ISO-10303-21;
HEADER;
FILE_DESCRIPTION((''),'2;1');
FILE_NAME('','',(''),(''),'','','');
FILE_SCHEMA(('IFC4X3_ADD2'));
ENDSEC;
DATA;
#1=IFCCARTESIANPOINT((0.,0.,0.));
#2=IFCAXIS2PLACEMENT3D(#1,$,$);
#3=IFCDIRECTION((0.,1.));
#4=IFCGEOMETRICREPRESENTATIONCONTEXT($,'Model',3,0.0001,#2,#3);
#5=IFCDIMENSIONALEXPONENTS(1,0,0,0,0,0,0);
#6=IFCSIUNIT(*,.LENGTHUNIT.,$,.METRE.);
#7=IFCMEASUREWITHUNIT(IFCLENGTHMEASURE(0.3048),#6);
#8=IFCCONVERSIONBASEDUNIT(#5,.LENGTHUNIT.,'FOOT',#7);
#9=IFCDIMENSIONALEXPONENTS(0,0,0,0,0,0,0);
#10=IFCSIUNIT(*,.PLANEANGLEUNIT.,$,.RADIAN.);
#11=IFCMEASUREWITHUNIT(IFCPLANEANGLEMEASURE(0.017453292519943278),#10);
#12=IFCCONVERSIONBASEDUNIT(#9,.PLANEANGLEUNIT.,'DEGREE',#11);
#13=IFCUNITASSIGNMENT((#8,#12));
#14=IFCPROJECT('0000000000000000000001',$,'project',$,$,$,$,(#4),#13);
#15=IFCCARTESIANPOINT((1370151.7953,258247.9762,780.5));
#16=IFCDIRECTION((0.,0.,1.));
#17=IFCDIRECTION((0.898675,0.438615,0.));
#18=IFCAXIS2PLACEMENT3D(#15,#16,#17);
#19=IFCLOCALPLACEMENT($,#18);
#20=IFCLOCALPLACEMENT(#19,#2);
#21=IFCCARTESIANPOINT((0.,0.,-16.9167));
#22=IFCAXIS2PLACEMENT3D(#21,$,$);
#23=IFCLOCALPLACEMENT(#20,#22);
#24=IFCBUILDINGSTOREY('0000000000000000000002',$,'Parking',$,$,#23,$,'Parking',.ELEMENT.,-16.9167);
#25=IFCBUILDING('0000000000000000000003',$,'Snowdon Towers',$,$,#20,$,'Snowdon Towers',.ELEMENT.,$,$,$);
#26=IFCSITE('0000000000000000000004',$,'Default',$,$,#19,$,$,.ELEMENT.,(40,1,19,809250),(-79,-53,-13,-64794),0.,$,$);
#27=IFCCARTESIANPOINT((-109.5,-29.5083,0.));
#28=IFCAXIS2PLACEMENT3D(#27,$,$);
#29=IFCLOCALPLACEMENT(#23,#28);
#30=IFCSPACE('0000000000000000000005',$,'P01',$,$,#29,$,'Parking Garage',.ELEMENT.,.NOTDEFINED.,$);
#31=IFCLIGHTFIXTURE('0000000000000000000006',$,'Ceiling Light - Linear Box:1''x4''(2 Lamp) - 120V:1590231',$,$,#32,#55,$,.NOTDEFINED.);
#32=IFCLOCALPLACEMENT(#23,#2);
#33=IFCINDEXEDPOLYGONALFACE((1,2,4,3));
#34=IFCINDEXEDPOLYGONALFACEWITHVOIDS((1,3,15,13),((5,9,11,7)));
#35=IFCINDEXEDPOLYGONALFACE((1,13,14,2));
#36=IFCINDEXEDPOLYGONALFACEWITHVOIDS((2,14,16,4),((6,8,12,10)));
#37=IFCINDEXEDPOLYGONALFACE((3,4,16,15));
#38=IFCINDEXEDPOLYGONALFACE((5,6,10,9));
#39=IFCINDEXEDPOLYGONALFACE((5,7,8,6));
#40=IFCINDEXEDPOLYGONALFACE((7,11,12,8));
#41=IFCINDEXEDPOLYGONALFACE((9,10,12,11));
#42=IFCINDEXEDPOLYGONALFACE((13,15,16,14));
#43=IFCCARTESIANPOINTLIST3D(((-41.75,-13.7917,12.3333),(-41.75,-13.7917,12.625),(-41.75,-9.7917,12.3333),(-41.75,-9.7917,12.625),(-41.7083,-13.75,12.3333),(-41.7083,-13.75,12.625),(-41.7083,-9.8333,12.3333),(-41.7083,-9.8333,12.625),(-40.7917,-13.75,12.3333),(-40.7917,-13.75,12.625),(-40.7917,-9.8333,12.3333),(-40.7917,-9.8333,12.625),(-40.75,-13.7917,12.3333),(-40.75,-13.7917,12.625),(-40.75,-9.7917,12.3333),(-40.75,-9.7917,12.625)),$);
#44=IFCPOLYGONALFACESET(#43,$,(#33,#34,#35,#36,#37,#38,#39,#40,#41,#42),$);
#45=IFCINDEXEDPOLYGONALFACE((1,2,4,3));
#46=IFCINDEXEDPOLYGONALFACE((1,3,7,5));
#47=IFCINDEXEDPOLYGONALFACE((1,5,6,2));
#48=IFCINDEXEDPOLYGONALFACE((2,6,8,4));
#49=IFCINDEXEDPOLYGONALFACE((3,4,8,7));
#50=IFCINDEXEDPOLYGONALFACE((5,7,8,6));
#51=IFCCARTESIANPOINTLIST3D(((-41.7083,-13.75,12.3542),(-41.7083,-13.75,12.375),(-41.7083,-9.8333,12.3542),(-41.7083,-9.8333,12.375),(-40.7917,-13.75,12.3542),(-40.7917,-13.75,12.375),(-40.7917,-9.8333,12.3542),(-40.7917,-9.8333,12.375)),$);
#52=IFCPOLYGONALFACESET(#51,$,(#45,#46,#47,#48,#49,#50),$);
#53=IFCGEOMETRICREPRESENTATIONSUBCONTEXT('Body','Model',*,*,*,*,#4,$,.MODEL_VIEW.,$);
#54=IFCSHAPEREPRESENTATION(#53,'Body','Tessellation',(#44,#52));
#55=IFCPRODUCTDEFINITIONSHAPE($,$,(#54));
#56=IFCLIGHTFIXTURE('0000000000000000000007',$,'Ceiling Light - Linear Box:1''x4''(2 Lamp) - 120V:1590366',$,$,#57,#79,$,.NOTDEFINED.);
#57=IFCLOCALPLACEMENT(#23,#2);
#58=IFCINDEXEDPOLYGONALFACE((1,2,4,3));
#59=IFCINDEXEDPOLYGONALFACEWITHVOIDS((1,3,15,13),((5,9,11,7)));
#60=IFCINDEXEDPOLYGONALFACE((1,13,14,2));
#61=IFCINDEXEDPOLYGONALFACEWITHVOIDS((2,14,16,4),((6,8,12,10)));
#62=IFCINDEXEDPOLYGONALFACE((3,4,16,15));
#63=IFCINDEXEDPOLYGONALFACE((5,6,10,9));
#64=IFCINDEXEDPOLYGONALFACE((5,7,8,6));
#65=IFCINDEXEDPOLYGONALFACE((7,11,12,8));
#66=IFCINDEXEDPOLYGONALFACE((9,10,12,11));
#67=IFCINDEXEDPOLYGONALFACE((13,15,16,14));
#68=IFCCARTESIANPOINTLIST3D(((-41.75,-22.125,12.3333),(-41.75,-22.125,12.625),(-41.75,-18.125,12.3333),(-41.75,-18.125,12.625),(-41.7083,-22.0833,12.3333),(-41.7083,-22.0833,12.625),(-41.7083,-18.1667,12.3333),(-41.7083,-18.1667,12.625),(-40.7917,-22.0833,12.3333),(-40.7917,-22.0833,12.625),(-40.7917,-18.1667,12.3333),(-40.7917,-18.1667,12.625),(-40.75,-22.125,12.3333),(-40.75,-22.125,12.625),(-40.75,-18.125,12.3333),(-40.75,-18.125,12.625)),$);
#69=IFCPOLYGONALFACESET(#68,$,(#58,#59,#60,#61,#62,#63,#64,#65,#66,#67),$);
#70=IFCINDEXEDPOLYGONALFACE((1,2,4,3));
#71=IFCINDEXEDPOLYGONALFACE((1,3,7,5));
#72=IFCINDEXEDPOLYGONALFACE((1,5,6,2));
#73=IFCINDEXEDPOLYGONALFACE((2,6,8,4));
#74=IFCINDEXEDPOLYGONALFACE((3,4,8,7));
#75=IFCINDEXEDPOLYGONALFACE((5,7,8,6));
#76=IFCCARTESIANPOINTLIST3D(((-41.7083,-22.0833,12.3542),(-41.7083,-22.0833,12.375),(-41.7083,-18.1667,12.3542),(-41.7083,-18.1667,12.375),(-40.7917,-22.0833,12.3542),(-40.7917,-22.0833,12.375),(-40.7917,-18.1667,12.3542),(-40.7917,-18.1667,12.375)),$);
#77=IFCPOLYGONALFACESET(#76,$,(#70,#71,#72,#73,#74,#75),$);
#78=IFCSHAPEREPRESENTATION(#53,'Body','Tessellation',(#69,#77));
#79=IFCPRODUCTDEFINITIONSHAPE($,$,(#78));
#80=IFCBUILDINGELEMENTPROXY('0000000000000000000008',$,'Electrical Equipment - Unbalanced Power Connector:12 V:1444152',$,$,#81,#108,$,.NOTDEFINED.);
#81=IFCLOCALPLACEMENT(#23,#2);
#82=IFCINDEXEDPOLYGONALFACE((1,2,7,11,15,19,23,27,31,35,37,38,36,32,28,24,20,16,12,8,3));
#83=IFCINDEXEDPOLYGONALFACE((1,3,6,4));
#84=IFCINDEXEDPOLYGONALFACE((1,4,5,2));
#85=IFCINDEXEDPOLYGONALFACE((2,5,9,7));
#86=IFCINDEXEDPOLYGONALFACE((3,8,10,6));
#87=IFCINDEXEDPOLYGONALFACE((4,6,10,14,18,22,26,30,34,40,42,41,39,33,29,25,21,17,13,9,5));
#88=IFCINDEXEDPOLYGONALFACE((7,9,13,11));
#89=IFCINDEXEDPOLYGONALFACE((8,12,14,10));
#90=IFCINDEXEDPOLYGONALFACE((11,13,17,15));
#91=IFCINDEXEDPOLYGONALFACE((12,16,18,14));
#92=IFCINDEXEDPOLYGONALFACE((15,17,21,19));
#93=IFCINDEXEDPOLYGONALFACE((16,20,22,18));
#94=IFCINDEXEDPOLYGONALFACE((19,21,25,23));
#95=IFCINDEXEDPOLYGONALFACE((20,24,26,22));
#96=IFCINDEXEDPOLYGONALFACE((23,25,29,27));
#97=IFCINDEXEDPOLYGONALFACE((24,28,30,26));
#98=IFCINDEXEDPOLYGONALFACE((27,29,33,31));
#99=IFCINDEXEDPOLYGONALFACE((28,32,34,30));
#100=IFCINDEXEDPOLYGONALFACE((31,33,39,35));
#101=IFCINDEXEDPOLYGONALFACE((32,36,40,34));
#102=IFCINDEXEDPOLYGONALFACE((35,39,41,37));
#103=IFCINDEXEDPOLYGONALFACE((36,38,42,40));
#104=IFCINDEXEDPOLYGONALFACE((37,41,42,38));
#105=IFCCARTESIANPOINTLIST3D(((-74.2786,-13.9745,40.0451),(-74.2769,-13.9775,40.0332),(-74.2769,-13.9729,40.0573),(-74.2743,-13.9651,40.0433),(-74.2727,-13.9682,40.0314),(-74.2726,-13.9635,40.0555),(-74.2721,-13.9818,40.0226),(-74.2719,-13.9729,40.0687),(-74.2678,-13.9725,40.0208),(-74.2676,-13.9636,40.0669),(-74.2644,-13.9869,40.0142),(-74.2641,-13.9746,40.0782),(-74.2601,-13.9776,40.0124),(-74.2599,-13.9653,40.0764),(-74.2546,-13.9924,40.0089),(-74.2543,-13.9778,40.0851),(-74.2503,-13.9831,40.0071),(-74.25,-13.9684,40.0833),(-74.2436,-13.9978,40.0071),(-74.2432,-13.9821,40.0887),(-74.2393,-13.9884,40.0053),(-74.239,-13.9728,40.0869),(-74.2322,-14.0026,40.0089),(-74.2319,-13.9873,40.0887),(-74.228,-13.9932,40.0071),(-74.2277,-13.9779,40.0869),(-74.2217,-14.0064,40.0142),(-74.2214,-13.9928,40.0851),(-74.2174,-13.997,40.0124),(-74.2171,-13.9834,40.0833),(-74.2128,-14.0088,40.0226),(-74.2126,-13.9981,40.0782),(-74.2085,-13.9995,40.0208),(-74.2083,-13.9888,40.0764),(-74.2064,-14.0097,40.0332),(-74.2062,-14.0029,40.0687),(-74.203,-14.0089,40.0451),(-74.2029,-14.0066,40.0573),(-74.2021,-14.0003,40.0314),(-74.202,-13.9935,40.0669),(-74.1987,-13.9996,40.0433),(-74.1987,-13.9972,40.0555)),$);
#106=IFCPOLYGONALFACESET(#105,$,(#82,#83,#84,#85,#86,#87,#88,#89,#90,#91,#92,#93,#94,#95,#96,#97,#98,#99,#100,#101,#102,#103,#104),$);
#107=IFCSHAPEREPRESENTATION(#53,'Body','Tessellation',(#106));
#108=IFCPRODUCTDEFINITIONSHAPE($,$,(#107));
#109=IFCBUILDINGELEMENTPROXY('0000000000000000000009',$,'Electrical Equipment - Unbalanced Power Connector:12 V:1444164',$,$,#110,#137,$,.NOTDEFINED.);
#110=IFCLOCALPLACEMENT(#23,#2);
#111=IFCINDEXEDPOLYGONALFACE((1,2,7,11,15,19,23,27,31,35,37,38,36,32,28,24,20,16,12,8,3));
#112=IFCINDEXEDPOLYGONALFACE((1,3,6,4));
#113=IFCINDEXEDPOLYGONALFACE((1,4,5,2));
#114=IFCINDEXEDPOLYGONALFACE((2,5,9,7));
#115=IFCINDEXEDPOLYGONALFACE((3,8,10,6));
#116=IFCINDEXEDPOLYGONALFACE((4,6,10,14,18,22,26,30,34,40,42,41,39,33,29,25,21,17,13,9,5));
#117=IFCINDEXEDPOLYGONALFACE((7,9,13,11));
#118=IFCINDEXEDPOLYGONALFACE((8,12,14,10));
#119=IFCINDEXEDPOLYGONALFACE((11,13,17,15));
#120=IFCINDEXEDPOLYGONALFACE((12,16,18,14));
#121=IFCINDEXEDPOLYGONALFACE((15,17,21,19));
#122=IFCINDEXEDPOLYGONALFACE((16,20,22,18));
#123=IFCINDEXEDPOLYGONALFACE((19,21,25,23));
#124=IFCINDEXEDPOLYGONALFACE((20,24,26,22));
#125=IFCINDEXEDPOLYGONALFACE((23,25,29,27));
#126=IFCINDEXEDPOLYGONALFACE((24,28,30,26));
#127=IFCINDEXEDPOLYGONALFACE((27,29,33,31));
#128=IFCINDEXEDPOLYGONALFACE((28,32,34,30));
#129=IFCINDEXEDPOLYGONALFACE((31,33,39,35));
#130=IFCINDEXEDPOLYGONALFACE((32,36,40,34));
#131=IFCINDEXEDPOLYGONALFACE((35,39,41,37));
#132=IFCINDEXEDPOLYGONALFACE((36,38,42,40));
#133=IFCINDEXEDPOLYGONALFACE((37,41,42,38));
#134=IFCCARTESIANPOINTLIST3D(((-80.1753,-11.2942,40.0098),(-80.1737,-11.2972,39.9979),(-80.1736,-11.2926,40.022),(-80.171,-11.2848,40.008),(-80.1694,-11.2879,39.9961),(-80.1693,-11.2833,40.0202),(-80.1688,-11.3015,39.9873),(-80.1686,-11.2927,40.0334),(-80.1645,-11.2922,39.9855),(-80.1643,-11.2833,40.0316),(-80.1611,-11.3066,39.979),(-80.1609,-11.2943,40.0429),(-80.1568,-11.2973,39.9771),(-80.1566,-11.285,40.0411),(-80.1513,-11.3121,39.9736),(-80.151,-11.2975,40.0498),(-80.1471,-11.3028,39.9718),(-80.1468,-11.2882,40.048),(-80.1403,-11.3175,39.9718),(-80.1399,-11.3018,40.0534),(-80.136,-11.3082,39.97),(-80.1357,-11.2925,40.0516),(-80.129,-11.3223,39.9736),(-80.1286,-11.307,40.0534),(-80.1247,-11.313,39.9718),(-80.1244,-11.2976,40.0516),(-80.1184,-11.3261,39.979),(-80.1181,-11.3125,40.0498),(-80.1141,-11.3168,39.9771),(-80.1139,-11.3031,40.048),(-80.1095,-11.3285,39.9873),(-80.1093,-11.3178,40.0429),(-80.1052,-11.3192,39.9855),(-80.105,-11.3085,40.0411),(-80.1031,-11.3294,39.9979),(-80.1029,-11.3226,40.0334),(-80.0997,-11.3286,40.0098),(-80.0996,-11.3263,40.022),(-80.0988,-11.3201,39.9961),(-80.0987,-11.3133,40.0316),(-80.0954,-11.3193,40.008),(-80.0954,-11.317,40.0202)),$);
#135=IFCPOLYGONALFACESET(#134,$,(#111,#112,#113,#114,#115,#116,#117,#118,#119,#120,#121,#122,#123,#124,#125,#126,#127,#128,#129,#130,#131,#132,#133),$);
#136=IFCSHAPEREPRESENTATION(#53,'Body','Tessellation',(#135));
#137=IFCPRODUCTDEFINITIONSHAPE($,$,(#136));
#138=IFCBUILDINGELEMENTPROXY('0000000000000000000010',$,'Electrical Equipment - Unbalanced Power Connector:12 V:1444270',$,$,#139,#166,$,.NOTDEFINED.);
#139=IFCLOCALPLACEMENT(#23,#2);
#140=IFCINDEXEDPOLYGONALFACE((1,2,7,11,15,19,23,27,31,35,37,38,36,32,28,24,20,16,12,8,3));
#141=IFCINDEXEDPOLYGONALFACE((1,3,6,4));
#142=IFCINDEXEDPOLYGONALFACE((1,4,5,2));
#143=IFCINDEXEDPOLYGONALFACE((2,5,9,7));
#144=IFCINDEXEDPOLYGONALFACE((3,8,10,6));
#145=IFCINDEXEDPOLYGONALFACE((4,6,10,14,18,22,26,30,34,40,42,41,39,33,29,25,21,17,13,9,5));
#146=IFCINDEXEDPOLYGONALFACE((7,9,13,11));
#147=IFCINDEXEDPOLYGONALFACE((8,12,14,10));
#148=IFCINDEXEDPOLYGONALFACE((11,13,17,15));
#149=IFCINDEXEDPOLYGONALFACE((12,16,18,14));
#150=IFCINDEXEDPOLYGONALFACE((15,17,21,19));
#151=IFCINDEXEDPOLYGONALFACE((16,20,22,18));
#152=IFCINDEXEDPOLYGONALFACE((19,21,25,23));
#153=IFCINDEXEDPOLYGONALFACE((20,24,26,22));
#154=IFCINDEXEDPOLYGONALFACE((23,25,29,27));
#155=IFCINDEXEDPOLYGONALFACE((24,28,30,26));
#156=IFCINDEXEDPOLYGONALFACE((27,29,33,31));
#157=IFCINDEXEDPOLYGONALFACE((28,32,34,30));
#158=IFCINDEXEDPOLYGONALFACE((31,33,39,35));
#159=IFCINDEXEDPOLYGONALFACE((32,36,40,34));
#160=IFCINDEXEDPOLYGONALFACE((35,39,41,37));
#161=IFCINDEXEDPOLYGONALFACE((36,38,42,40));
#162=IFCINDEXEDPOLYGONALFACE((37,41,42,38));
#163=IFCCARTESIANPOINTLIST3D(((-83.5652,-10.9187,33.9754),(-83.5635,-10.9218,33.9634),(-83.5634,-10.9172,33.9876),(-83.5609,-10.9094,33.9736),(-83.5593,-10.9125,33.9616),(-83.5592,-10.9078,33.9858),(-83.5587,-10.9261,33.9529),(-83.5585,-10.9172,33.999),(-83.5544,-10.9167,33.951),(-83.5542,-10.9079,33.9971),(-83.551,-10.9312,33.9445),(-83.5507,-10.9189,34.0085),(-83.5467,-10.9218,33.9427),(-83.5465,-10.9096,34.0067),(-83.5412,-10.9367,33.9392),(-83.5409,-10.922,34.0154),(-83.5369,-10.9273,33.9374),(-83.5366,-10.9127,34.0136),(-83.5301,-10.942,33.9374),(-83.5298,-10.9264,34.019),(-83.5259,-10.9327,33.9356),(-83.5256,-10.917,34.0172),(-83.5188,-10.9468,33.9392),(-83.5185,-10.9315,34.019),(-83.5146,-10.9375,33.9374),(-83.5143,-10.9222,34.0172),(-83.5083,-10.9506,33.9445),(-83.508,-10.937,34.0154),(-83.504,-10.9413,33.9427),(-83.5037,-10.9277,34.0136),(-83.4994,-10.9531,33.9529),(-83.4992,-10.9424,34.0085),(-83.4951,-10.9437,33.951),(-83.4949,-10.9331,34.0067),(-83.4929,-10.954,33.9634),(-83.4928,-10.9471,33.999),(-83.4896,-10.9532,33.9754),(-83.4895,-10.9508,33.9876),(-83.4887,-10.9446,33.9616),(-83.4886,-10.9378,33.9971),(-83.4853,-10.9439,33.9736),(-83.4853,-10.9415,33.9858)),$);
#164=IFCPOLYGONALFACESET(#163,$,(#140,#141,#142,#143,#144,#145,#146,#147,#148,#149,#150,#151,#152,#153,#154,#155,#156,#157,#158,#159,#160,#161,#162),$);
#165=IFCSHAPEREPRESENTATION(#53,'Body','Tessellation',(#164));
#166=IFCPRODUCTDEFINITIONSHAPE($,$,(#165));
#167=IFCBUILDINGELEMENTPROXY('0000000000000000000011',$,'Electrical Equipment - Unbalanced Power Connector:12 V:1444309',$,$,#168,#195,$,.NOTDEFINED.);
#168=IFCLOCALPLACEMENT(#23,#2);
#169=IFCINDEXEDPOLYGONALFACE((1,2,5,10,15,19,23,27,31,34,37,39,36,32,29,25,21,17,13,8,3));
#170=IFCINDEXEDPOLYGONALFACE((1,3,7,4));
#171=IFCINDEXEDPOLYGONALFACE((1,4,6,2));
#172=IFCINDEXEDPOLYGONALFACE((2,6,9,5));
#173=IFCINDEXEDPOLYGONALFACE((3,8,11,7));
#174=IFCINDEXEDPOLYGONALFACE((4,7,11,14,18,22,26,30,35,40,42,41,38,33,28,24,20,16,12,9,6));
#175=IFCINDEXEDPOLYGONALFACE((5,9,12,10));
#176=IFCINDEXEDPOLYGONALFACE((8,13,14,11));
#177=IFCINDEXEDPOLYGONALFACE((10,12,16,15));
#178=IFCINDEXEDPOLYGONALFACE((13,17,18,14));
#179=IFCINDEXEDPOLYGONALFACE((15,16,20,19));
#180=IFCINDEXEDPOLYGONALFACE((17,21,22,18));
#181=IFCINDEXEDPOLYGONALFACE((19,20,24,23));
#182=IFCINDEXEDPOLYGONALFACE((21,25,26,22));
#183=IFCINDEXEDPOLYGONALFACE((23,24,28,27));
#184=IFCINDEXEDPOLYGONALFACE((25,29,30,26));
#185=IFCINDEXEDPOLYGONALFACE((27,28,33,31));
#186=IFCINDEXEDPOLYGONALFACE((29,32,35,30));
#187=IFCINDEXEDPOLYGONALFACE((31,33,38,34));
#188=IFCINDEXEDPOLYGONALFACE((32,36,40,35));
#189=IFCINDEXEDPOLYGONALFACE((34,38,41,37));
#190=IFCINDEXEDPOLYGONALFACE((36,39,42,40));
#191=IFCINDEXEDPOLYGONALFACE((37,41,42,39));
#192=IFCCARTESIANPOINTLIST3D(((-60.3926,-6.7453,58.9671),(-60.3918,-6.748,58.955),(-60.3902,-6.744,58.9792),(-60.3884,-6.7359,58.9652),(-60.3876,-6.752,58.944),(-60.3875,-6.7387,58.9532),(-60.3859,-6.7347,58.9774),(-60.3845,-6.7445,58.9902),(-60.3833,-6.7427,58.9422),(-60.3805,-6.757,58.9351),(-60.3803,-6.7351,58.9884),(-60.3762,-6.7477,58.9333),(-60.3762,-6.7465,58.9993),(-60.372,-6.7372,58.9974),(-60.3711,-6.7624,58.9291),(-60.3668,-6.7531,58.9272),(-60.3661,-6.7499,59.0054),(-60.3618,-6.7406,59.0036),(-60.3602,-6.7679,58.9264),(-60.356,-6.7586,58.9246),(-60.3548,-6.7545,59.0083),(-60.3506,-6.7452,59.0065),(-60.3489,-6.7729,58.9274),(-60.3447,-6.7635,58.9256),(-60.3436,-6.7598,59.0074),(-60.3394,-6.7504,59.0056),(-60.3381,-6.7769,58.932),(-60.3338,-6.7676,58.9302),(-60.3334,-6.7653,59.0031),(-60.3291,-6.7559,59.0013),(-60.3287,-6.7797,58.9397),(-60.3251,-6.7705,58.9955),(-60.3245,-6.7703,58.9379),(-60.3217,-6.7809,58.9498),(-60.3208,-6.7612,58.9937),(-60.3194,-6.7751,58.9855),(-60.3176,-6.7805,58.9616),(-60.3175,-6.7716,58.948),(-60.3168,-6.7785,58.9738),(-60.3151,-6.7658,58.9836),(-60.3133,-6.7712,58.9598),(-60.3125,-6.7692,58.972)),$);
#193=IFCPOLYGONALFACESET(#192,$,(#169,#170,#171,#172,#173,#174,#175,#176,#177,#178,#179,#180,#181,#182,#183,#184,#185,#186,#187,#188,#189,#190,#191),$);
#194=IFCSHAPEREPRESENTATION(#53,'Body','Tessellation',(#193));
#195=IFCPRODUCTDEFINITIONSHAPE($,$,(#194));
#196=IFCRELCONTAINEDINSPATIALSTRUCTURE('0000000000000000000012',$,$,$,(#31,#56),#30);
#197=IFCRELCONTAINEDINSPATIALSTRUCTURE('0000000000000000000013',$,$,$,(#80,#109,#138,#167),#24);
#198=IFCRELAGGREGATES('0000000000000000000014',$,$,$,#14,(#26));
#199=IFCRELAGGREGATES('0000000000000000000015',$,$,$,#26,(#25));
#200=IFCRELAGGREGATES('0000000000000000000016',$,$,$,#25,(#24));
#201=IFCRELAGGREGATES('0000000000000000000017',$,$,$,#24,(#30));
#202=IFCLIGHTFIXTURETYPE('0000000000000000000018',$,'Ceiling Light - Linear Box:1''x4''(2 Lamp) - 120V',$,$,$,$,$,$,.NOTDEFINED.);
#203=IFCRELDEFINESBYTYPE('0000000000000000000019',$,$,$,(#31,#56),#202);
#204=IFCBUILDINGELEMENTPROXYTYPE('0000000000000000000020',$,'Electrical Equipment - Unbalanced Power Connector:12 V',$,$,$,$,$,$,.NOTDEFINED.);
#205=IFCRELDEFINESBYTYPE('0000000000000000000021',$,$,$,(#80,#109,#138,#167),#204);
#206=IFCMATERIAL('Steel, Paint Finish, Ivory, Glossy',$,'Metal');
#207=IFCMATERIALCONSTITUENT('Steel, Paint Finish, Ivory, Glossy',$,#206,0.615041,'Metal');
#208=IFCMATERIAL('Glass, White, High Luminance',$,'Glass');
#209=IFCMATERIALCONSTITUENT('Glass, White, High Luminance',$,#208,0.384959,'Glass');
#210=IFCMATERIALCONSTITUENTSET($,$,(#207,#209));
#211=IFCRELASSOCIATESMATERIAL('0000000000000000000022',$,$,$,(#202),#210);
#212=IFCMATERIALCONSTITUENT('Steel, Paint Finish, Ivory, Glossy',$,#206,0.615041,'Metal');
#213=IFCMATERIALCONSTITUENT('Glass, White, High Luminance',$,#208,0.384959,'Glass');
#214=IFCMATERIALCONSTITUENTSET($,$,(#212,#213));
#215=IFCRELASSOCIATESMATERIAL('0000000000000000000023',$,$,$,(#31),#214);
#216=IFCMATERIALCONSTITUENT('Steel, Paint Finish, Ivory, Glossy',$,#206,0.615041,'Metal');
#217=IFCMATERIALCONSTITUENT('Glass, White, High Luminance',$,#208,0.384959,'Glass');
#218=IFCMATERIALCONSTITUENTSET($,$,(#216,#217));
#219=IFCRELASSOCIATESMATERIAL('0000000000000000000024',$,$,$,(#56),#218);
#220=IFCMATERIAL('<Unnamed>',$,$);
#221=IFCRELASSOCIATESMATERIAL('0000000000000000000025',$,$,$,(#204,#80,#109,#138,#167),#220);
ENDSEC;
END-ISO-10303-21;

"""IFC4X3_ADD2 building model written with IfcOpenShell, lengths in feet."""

from ifc_helpers import new_model, entity, si_unit, converted_unit, direction, frame, frame_2d, origin, origin_2d_with_axis, place, context, subcontext, project, spatial, polyline, rectangle, circle, outline, extrude, source, transform, mapped, material, constituent, constituent_set, type_object, type_shapes, element, save


model = new_model("IFC4X3_ADD2")

# Units and contexts
model_context = context("Model", 3, precision=0.0001, world=origin(), true_north=direction((0.0, 1.0)))
body_context = subcontext(model_context, "Body", "Model", "MODEL_VIEW")
ifc_project = project(units=[converted_unit("LENGTHUNIT", "FOOT", entity("IfcLengthMeasure", 0.3048), si_unit("LENGTHUNIT", "METRE"), dimensions=[1, 0, 0, 0, 0, 0, 0]), converted_unit("PLANEANGLEUNIT", "DEGREE", entity("IfcPlaneAngleMeasure", 0.017453292519943278), si_unit("PLANEANGLEUNIT", "RADIAN"), dimensions=[0, 0, 0, 0, 0, 0, 0])], contexts=[model_context])

# Site, building, storey
site_placement = place(None, frame((1370151.7953, 258247.9762, 780.5), z_axis=(0.0, 0.0, 1.0), x_axis=(0.898675, 0.438615, 0.0)))
site = spatial("IfcSite", under=ifc_project, at=site_placement, Name="Default", CompositionType="ELEMENT", RefLatitude=(40, 1, 19, 809250), RefLongitude=(-79, -53, -13, -64794), RefElevation=0.0)
building_placement = place(site_placement, origin())
building = spatial("IfcBuilding", under=site, at=building_placement, Name="Snowdon Towers", LongName="Snowdon Towers", CompositionType="ELEMENT")
storey_placement = place(building_placement, frame((0.0, 0.0, -16.9167)))
storey = spatial("IfcBuildingStorey", under=building, at=storey_placement, Name="Parking", LongName="Parking", CompositionType="ELEMENT", Elevation=-16.9167)

# Shared definitions
space_placement = place(storey_placement, frame((-109.5, -29.5083, 0.0)))
space = spatial("IfcSpace", under=storey, at=space_placement, Name="P01", LongName="Parking Garage", CompositionType="ELEMENT", PredefinedType="NOTDEFINED")

# Light fixtures
ifc_material_1 = material(Name="Steel, Paint Finish, Ivory, Glossy", Category="Metal")
ifc_constituent_1 = constituent(ifc_material_1, Name="Steel, Paint Finish, Ivory, Glossy", Category="Metal", fraction=0.615041)
ifc_material_2 = material(Name="Glass, White, High Luminance", Category="Glass")
ifc_constituent_2 = constituent(ifc_material_2, Name="Glass, White, High Luminance", Category="Glass", fraction=0.384959)
ifc_constituent_set_1 = constituent_set(constituents=[ifc_constituent_1, ifc_constituent_2])
ifc_constituent_3 = constituent(ifc_material_1, Name="Steel, Paint Finish, Ivory, Glossy", Category="Metal", fraction=0.615041)
ifc_constituent_4 = constituent(ifc_material_2, Name="Glass, White, High Luminance", Category="Glass", fraction=0.384959)
ifc_constituent_set_2 = constituent_set(constituents=[ifc_constituent_3, ifc_constituent_4])
light_fixture_type = type_object("IfcLightFixtureType", Name="Ceiling Light - Linear Box:1'x4'(2 Lamp) - 120V", PredefinedType="NOTDEFINED", material=ifc_constituent_set_2)
shared_shape_1 = source(origin(), body_context, "Body", "SweptSolid", [
    extrude(outline(polyline([(-2.0, -0.5), (2.0, -0.5), (2.0, 0.5), (-2.0, 0.5), (-2.0, -0.5)]), holes=[polyline([(-1.9583, -0.4583), (-1.9583, 0.4583), (1.9583, 0.4583), (1.9583, -0.4583), (-1.9583, -0.4583)])]), frame((0.0, -0.5, 0.0), z_axis=(0.0, 0.0, 1.0), x_axis=(-1.0, 0.0, 0.0)), (0.0, 0.0, 1.0), 0.2917),
    extrude(rectangle(XDim=3.9167, YDim=0.9167, at=origin_2d_with_axis()), frame((0.0, -0.5, 0.25), z_axis=(0.0, 0.0, 1.0), x_axis=(-1.0, 0.0, 0.0)), (0.0, 0.0, 1.0), 0.0208),
])
type_shapes(light_fixture_type, [shared_shape_1])
light_fixture_1_placement = place(space_placement, frame((67.75, 17.7166, 12.625), z_axis=(0.0, 0.0, -1.0), x_axis=(0.0, -1.0, 0.0)))
element("IfcLightFixture", 1, at=light_fixture_1_placement, inside=space, type_object=light_fixture_type, material=ifc_constituent_set_1, Name="Ceiling Light - Linear Box:1'x4'(2 Lamp) - 120V:1590231", PredefinedType="NOTDEFINED", context=body_context, shape_type="MappedRepresentation", body=[
    mapped(shared_shape_1, transform((0.0, 0.0, 0.0), scale=1.0)),
])
ifc_constituent_5 = constituent(ifc_material_1, Name="Steel, Paint Finish, Ivory, Glossy", Category="Metal", fraction=0.615041)
ifc_constituent_6 = constituent(ifc_material_2, Name="Glass, White, High Luminance", Category="Glass", fraction=0.384959)
ifc_constituent_set_3 = constituent_set(constituents=[ifc_constituent_5, ifc_constituent_6])
light_fixture_2_placement = place(space_placement, frame((67.75, 9.3833, 12.625), z_axis=(0.0, 0.0, -1.0), x_axis=(0.0, -1.0, 0.0)))
element("IfcLightFixture", 2, at=light_fixture_2_placement, inside=space, type_object=light_fixture_type, material=ifc_constituent_set_3, Name="Ceiling Light - Linear Box:1'x4'(2 Lamp) - 120V:1590366", PredefinedType="NOTDEFINED", context=body_context, shape_type="MappedRepresentation", body=[
    mapped(shared_shape_1, transform((0.0, 0.0, 0.0), scale=1.0)),
])

# Building element proxies
ifc_material_3 = material(Name="<Unnamed>")
building_element_proxy_type = type_object("IfcBuildingElementProxyType", Name="Electrical Equipment - Unbalanced Power Connector:12 V", PredefinedType="NOTDEFINED", material=ifc_material_3)
shared_shape_2 = source(origin(), body_context, "Body", "SweptSolid", [
    extrude(circle(Radius=0.0417, at=frame_2d((0.0, 0.0), x_axis=(1.0, 0.0))), origin(), (0.0, 0.0, 1.0), 0.0104),
])
type_shapes(building_element_proxy_type, [shared_shape_2])
for number, where, z_axis, x_axis, name in (
    (3, (-74.2406, -13.9912, 40.0482), (0.408371, 0.896147, -0.173648), (-0.072007, -0.158015, -0.984808), "Electrical Equipment - Unbalanced Power Connector:12 V:1444152"),
    (4, (-80.1373, -11.3109, 40.0129), (0.408371, 0.896147, -0.173648), (-0.072007, -0.158015, -0.984808), "Electrical Equipment - Unbalanced Power Connector:12 V:1444164"),
    (5, (-83.5271, -10.9355, 33.9784), (0.408371, 0.896147, -0.173648), (-0.072007, -0.158015, -0.984808), "Electrical Equipment - Unbalanced Power Connector:12 V:1444270"),
    (6, (-60.3547, -6.7625, 58.9674), (0.408371, 0.896147, -0.173648), (-0.132859, -0.129855, -0.982592), "Electrical Equipment - Unbalanced Power Connector:12 V:1444309"),
):
    element("IfcBuildingElementProxy", number, at=place(storey_placement, frame(where, z_axis=z_axis, x_axis=x_axis)), inside=storey, type_object=building_element_proxy_type, material=ifc_material_3, Name=name, PredefinedType="NOTDEFINED", context=body_context, shape_type="MappedRepresentation", body=[
        mapped(shared_shape_2, transform((0.0, 0.0, 0.0), scale=1.0)),
    ])

save(model, "model.ifc")
